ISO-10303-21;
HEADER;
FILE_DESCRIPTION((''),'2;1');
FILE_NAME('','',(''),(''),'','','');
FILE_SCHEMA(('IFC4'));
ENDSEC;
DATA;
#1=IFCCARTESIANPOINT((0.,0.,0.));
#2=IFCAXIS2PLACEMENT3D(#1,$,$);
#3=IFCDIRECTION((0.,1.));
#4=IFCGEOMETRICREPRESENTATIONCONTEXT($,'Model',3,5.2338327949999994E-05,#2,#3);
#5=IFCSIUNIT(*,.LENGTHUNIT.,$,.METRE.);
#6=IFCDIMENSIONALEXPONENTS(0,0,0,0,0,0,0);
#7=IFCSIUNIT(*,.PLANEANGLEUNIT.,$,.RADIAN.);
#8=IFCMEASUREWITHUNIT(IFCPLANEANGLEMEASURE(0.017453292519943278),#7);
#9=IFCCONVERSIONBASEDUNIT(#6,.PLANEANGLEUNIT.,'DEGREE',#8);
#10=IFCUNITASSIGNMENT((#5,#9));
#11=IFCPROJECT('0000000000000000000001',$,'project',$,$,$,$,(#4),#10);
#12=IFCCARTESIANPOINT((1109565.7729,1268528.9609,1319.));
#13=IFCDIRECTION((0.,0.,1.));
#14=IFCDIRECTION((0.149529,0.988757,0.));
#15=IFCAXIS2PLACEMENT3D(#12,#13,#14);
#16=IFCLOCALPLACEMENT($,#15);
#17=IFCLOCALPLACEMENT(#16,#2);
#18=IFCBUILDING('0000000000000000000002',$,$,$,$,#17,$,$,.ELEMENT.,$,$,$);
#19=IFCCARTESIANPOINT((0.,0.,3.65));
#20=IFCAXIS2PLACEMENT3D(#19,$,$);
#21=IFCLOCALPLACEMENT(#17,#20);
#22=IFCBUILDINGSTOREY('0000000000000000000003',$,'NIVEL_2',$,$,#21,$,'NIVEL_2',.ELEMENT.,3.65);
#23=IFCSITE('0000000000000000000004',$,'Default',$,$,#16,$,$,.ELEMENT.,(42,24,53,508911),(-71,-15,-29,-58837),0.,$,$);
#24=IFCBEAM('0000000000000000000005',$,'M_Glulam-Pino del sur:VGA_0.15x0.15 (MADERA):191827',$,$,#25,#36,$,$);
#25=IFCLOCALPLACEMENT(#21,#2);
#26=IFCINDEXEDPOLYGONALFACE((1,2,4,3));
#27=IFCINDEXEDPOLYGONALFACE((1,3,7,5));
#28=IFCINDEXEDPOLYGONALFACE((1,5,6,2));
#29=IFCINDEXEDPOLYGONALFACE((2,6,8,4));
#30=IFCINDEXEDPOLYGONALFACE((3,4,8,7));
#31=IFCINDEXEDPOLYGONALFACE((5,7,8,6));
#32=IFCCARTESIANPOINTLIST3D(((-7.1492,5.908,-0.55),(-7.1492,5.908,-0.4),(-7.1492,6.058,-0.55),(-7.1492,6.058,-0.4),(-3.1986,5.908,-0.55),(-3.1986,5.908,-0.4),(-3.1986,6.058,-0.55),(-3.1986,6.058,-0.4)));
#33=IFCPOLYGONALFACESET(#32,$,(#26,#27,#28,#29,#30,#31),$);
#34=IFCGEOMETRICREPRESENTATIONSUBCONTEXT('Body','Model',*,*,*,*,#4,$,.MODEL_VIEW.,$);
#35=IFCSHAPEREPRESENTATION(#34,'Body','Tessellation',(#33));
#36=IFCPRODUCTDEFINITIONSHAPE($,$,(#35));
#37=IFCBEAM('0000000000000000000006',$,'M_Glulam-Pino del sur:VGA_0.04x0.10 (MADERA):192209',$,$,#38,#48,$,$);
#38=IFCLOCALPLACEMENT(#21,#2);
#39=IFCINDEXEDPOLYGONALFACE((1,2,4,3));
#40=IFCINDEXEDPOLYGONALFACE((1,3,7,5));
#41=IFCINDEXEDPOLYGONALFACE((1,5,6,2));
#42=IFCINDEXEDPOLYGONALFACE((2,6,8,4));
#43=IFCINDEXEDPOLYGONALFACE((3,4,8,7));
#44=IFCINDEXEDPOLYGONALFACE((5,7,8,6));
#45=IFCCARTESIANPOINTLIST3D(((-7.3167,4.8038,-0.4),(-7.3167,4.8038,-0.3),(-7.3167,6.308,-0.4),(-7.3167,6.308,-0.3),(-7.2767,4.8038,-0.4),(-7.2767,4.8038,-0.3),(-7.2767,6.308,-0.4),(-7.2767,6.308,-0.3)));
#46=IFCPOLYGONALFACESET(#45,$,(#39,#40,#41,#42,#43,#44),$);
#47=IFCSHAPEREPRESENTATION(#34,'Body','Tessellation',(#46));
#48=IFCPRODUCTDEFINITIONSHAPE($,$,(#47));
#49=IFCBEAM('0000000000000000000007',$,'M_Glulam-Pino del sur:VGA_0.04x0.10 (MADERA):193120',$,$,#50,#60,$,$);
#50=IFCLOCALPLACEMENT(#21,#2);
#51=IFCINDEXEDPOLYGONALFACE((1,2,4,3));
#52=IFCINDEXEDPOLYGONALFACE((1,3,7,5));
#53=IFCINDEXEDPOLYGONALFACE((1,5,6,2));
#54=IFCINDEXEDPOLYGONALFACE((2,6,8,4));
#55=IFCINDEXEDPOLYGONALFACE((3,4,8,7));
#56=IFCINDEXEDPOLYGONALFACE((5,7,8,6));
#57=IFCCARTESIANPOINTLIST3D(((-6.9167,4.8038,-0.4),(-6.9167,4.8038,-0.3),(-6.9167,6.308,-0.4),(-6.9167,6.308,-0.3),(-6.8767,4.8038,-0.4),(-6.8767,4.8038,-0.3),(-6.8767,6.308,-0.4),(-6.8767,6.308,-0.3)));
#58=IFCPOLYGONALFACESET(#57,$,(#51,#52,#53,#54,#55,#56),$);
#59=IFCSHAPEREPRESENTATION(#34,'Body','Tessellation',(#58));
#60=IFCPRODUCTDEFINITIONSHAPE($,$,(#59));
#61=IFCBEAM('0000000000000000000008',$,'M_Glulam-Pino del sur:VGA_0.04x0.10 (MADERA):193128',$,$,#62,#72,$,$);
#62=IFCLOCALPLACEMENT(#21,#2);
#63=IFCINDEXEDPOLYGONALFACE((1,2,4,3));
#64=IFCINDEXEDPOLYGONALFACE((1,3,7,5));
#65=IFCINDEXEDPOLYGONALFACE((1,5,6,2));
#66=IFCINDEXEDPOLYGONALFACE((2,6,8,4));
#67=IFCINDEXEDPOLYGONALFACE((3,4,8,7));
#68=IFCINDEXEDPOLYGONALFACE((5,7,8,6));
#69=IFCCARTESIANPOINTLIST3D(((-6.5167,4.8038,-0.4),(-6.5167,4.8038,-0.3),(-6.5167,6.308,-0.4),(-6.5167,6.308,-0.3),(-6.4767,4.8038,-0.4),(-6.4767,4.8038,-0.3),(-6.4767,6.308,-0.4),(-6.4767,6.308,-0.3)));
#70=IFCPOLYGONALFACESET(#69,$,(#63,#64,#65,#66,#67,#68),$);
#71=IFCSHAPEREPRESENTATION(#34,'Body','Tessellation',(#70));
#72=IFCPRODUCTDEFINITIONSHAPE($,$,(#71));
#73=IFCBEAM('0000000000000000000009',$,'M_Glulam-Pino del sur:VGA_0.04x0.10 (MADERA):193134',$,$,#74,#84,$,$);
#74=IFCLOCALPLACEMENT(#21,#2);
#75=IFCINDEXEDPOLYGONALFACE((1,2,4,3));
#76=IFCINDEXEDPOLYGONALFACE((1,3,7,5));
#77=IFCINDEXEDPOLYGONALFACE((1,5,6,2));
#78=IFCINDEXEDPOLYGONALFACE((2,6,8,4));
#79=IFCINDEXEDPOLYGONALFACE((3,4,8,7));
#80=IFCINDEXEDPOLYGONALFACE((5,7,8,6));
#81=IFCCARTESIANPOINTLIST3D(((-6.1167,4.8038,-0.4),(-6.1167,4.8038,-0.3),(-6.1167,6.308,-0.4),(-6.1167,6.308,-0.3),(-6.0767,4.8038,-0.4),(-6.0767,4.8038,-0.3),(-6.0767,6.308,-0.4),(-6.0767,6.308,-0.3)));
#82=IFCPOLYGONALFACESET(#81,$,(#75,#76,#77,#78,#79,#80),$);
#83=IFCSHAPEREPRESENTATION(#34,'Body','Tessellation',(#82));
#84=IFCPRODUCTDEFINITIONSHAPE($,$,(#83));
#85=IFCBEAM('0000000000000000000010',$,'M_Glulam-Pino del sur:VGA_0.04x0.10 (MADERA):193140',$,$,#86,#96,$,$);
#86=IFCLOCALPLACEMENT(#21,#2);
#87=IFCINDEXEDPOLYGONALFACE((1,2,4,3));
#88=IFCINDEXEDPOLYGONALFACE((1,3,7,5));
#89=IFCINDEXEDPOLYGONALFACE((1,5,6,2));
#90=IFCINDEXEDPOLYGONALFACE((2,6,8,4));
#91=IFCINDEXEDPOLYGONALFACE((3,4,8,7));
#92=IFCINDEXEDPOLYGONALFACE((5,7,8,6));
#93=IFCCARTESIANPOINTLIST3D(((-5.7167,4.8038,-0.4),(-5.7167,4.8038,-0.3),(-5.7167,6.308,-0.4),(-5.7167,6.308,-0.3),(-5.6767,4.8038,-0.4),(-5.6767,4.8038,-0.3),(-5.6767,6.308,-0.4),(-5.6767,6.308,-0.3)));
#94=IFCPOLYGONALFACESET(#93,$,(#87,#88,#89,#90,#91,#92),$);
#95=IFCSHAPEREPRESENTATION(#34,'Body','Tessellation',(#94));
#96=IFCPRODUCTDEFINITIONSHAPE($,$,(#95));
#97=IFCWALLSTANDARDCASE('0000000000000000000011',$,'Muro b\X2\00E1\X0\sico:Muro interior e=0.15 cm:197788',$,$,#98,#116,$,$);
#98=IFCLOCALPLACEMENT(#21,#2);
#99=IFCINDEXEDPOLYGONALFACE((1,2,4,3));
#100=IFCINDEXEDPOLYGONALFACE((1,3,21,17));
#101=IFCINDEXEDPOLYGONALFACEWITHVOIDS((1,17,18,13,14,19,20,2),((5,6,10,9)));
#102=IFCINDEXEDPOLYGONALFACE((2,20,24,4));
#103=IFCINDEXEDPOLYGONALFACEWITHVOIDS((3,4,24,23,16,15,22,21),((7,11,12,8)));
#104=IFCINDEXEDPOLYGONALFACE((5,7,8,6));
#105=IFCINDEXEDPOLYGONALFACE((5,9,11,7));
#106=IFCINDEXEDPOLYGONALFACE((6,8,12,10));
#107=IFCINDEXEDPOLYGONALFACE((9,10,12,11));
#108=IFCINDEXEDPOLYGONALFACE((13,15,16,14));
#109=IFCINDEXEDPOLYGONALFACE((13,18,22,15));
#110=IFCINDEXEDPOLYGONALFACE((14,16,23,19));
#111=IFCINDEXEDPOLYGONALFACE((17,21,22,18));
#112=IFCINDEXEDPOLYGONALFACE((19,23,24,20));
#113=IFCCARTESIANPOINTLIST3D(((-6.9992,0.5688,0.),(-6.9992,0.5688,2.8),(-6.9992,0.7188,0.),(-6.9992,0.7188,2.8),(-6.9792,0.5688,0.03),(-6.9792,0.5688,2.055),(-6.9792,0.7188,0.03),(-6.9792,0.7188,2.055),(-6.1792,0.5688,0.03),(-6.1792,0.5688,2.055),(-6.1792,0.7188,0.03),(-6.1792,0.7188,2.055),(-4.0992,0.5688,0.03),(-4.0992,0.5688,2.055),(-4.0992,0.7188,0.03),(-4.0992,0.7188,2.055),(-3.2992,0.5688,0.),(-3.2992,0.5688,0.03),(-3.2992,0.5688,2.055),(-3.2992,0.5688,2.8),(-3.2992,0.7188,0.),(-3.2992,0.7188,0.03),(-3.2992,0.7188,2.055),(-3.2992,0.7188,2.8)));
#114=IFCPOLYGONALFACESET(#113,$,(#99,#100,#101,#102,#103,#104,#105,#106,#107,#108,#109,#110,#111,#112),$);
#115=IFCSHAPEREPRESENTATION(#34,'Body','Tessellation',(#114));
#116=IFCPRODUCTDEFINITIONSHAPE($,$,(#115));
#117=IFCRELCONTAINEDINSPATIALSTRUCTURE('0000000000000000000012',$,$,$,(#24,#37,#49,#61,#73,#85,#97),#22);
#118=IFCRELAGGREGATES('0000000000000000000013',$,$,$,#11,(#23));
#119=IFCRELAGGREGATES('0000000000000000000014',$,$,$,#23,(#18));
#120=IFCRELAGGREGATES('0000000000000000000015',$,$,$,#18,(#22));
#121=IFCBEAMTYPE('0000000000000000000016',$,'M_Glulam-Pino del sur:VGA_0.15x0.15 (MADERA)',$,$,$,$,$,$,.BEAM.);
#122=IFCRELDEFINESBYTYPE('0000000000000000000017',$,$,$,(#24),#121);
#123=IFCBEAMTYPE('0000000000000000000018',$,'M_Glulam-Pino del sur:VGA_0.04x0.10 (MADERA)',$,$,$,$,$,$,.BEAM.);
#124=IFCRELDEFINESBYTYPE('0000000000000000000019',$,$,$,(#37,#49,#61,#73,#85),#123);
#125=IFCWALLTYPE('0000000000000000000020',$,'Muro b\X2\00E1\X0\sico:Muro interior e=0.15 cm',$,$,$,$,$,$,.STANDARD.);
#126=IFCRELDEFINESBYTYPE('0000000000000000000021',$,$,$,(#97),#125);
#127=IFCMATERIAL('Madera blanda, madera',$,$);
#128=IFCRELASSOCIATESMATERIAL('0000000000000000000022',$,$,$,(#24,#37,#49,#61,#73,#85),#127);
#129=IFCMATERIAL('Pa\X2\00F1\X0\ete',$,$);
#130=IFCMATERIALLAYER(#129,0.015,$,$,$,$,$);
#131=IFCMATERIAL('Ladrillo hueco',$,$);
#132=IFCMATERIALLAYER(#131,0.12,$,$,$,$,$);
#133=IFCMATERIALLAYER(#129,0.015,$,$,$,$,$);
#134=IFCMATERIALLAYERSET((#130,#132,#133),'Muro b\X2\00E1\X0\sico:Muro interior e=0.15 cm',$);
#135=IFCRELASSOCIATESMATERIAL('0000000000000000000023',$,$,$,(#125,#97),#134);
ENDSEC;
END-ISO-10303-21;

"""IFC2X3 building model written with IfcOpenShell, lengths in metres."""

from ifc_helpers import new_model, entity, si_unit, converted_unit, direction, frame, frame_2d, origin, origin_2d_with_axis, place, context, subcontext, project, spatial, rectangle, extrude, material, layer, layer_set, layer_usage, type_object, element, save


model = new_model("IFC2X3")

# Units and contexts
model_context = context("Model", 3, precision=5.2338327949999994e-05, world=origin(), true_north=direction((0.0, 1.0)))
body_context = subcontext(model_context, "Body", "Model", "MODEL_VIEW")
ifc_project = project(units=[si_unit("LENGTHUNIT", "METRE"), converted_unit("PLANEANGLEUNIT", "DEGREE", entity("IfcPlaneAngleMeasure", 0.017453292519943278), si_unit("PLANEANGLEUNIT", "RADIAN"), dimensions=[0, 0, 0, 0, 0, 0, 0])], contexts=[model_context])

# Site, building, storey
site_placement = place(None, frame((1109565.7729, 1268528.9609, 1319.0), z_axis=(0.0, 0.0, 1.0), x_axis=(0.149529, 0.988757, 0.0)))
site = spatial("IfcSite", under=ifc_project, at=site_placement, Name="Default", CompositionType="ELEMENT", RefLatitude=(42, 24, 53, 508911), RefLongitude=(-71, -15, -29, -58837), RefElevation=0.0)
building_placement = place(site_placement, origin())
building = spatial("IfcBuilding", under=site, at=building_placement, CompositionType="ELEMENT")
storey_placement = place(building_placement, frame((0.0, 0.0, 3.65)))
storey = spatial("IfcBuildingStorey", under=building, at=storey_placement, Name="NIVEL_2", LongName="NIVEL_2", CompositionType="ELEMENT", Elevation=3.65)

# Beams
ifc_material_1 = material(Name="Madera blanda, madera")
beam_type_1 = type_object("IfcBeamType", Name="M_Glulam-Pino del sur:VGA_0.15x0.15 (MADERA)", PredefinedType="BEAM")
beam_placement = place(storey_placement, frame((-7.1492, 5.983, -0.4)))
element("IfcBeam", 1, at=beam_placement, inside=storey, type_object=beam_type_1, material=ifc_material_1, Name="M_Glulam-Pino del sur:VGA_0.15x0.15 (MADERA):191827", context=body_context, shape_type="SweptSolid", body=[
    extrude(rectangle(XDim=0.15, YDim=0.15, at=frame_2d((0.0, 0.0), x_axis=(1.0, 0.0))), frame((0.0001, 0.0, -0.075), z_axis=(1.0, 0.0, 0.0), x_axis=(0.0, 0.0, -1.0)), (0.0, 0.0, 1.0), 3.9505),
])
beam_type_2 = type_object("IfcBeamType", Name="M_Glulam-Pino del sur:VGA_0.04x0.10 (MADERA)", PredefinedType="BEAM")
for number, where, z_axis, x_axis, name in (
    (2, (-7.2967, 4.8038, 0.0), (0.0, 0.0, 1.0), (0.0, 1.0, 0.0), "M_Glulam-Pino del sur:VGA_0.04x0.10 (MADERA):192209"),
    (3, (-6.8967, 4.8038, 0.0), (0.0, 0.0, 1.0), (0.0, 1.0, 0.0), "M_Glulam-Pino del sur:VGA_0.04x0.10 (MADERA):193120"),
    (4, (-6.4967, 4.8038, 0.0), (0.0, 0.0, 1.0), (0.0, 1.0, 0.0), "M_Glulam-Pino del sur:VGA_0.04x0.10 (MADERA):193128"),
    (5, (-6.0967, 4.8038, 0.0), (0.0, 0.0, 1.0), (0.0, 1.0, 0.0), "M_Glulam-Pino del sur:VGA_0.04x0.10 (MADERA):193134"),
    (6, (-5.6967, 4.8038, 0.0), (0.0, 0.0, 1.0), (0.0, 1.0, 0.0), "M_Glulam-Pino del sur:VGA_0.04x0.10 (MADERA):193140"),
):
    element("IfcBeam", number, at=place(storey_placement, frame(where, z_axis=z_axis, x_axis=x_axis)), inside=storey, type_object=beam_type_2, material=ifc_material_1, Name=name, context=body_context, shape_type="SweptSolid", body=[
        extrude(rectangle(XDim=0.1, YDim=0.04, at=origin_2d_with_axis()), frame((0.0, 0.0, -0.35), z_axis=(1.0, 0.0, 0.0), x_axis=(0.0, 0.0, -1.0)), (0.0, 0.0, 1.0), 1.5042),
    ])

# Wall, openings
ifc_material_2 = material(Name="Pañete")
ifc_layer_1 = layer(ifc_material_2, 0.015)
ifc_material_3 = material(Name="Ladrillo hueco")
ifc_layer_2 = layer(ifc_material_3, 0.12)
ifc_layer_3 = layer(ifc_material_2, 0.015)
ifc_layer_set_1 = layer_set([ifc_layer_1, ifc_layer_2, ifc_layer_3], Name="Muro básico:Muro interior e=0.15 cm")
ifc_layer_usage_1 = layer_usage(ifc_layer_set_1, "AXIS2", "NEGATIVE", 0.075)
wall_type_1 = type_object("IfcWallType", Name="Muro básico:Muro interior e=0.15 cm", PredefinedType="STANDARD", material=ifc_layer_set_1)
wall_1_placement = place(storey_placement, frame((-6.9992, 0.6438, 0.0)))
wall_1 = element("IfcWallStandardCase", 7, at=wall_1_placement, inside=storey, type_object=wall_type_1, material=ifc_layer_usage_1, Name="Muro básico:Muro interior e=0.15 cm:197788", context=body_context, shape_type="SweptSolid", body=[
    extrude(rectangle(XDim=3.7, YDim=0.15, at=frame_2d((1.85, 0.0), x_axis=(-1.0, 0.0))), origin(), (0.0, 0.0, 1.0), 2.8),
])
opening_1_placement = place(wall_1_placement, frame((2.9, -0.075, 0.03)))
element("IfcOpeningElement", 8, at=opening_1_placement, cuts=wall_1, ObjectType="Opening", context=body_context, shape_type="SweptSolid", body=[
    extrude(rectangle(XDim=2.025, YDim=0.8, at=frame_2d((1.0125, 0.4), x_axis=(1.0, 0.0))), frame((0.0, 0.0, 0.0), z_axis=(0.0, 1.0, 0.0), x_axis=(0.0, 0.0, 1.0)), (0.0, 0.0, 1.0), 0.15),
])
opening_2_placement = place(wall_1_placement, frame((0.82, 0.075, 0.03)))
element("IfcOpeningElement", 9, at=opening_2_placement, cuts=wall_1, ObjectType="Opening", context=body_context, shape_type="SweptSolid", body=[
    extrude(rectangle(XDim=2.025, YDim=0.8, at=frame_2d((1.0125, 0.4), x_axis=(1.0, 0.0))), frame((0.0, 0.0, 0.0), z_axis=(0.0, -1.0, 0.0), x_axis=(0.0, 0.0, 1.0)), (0.0, 0.0, 1.0), 0.15),
])

save(model, "model.ifc")
